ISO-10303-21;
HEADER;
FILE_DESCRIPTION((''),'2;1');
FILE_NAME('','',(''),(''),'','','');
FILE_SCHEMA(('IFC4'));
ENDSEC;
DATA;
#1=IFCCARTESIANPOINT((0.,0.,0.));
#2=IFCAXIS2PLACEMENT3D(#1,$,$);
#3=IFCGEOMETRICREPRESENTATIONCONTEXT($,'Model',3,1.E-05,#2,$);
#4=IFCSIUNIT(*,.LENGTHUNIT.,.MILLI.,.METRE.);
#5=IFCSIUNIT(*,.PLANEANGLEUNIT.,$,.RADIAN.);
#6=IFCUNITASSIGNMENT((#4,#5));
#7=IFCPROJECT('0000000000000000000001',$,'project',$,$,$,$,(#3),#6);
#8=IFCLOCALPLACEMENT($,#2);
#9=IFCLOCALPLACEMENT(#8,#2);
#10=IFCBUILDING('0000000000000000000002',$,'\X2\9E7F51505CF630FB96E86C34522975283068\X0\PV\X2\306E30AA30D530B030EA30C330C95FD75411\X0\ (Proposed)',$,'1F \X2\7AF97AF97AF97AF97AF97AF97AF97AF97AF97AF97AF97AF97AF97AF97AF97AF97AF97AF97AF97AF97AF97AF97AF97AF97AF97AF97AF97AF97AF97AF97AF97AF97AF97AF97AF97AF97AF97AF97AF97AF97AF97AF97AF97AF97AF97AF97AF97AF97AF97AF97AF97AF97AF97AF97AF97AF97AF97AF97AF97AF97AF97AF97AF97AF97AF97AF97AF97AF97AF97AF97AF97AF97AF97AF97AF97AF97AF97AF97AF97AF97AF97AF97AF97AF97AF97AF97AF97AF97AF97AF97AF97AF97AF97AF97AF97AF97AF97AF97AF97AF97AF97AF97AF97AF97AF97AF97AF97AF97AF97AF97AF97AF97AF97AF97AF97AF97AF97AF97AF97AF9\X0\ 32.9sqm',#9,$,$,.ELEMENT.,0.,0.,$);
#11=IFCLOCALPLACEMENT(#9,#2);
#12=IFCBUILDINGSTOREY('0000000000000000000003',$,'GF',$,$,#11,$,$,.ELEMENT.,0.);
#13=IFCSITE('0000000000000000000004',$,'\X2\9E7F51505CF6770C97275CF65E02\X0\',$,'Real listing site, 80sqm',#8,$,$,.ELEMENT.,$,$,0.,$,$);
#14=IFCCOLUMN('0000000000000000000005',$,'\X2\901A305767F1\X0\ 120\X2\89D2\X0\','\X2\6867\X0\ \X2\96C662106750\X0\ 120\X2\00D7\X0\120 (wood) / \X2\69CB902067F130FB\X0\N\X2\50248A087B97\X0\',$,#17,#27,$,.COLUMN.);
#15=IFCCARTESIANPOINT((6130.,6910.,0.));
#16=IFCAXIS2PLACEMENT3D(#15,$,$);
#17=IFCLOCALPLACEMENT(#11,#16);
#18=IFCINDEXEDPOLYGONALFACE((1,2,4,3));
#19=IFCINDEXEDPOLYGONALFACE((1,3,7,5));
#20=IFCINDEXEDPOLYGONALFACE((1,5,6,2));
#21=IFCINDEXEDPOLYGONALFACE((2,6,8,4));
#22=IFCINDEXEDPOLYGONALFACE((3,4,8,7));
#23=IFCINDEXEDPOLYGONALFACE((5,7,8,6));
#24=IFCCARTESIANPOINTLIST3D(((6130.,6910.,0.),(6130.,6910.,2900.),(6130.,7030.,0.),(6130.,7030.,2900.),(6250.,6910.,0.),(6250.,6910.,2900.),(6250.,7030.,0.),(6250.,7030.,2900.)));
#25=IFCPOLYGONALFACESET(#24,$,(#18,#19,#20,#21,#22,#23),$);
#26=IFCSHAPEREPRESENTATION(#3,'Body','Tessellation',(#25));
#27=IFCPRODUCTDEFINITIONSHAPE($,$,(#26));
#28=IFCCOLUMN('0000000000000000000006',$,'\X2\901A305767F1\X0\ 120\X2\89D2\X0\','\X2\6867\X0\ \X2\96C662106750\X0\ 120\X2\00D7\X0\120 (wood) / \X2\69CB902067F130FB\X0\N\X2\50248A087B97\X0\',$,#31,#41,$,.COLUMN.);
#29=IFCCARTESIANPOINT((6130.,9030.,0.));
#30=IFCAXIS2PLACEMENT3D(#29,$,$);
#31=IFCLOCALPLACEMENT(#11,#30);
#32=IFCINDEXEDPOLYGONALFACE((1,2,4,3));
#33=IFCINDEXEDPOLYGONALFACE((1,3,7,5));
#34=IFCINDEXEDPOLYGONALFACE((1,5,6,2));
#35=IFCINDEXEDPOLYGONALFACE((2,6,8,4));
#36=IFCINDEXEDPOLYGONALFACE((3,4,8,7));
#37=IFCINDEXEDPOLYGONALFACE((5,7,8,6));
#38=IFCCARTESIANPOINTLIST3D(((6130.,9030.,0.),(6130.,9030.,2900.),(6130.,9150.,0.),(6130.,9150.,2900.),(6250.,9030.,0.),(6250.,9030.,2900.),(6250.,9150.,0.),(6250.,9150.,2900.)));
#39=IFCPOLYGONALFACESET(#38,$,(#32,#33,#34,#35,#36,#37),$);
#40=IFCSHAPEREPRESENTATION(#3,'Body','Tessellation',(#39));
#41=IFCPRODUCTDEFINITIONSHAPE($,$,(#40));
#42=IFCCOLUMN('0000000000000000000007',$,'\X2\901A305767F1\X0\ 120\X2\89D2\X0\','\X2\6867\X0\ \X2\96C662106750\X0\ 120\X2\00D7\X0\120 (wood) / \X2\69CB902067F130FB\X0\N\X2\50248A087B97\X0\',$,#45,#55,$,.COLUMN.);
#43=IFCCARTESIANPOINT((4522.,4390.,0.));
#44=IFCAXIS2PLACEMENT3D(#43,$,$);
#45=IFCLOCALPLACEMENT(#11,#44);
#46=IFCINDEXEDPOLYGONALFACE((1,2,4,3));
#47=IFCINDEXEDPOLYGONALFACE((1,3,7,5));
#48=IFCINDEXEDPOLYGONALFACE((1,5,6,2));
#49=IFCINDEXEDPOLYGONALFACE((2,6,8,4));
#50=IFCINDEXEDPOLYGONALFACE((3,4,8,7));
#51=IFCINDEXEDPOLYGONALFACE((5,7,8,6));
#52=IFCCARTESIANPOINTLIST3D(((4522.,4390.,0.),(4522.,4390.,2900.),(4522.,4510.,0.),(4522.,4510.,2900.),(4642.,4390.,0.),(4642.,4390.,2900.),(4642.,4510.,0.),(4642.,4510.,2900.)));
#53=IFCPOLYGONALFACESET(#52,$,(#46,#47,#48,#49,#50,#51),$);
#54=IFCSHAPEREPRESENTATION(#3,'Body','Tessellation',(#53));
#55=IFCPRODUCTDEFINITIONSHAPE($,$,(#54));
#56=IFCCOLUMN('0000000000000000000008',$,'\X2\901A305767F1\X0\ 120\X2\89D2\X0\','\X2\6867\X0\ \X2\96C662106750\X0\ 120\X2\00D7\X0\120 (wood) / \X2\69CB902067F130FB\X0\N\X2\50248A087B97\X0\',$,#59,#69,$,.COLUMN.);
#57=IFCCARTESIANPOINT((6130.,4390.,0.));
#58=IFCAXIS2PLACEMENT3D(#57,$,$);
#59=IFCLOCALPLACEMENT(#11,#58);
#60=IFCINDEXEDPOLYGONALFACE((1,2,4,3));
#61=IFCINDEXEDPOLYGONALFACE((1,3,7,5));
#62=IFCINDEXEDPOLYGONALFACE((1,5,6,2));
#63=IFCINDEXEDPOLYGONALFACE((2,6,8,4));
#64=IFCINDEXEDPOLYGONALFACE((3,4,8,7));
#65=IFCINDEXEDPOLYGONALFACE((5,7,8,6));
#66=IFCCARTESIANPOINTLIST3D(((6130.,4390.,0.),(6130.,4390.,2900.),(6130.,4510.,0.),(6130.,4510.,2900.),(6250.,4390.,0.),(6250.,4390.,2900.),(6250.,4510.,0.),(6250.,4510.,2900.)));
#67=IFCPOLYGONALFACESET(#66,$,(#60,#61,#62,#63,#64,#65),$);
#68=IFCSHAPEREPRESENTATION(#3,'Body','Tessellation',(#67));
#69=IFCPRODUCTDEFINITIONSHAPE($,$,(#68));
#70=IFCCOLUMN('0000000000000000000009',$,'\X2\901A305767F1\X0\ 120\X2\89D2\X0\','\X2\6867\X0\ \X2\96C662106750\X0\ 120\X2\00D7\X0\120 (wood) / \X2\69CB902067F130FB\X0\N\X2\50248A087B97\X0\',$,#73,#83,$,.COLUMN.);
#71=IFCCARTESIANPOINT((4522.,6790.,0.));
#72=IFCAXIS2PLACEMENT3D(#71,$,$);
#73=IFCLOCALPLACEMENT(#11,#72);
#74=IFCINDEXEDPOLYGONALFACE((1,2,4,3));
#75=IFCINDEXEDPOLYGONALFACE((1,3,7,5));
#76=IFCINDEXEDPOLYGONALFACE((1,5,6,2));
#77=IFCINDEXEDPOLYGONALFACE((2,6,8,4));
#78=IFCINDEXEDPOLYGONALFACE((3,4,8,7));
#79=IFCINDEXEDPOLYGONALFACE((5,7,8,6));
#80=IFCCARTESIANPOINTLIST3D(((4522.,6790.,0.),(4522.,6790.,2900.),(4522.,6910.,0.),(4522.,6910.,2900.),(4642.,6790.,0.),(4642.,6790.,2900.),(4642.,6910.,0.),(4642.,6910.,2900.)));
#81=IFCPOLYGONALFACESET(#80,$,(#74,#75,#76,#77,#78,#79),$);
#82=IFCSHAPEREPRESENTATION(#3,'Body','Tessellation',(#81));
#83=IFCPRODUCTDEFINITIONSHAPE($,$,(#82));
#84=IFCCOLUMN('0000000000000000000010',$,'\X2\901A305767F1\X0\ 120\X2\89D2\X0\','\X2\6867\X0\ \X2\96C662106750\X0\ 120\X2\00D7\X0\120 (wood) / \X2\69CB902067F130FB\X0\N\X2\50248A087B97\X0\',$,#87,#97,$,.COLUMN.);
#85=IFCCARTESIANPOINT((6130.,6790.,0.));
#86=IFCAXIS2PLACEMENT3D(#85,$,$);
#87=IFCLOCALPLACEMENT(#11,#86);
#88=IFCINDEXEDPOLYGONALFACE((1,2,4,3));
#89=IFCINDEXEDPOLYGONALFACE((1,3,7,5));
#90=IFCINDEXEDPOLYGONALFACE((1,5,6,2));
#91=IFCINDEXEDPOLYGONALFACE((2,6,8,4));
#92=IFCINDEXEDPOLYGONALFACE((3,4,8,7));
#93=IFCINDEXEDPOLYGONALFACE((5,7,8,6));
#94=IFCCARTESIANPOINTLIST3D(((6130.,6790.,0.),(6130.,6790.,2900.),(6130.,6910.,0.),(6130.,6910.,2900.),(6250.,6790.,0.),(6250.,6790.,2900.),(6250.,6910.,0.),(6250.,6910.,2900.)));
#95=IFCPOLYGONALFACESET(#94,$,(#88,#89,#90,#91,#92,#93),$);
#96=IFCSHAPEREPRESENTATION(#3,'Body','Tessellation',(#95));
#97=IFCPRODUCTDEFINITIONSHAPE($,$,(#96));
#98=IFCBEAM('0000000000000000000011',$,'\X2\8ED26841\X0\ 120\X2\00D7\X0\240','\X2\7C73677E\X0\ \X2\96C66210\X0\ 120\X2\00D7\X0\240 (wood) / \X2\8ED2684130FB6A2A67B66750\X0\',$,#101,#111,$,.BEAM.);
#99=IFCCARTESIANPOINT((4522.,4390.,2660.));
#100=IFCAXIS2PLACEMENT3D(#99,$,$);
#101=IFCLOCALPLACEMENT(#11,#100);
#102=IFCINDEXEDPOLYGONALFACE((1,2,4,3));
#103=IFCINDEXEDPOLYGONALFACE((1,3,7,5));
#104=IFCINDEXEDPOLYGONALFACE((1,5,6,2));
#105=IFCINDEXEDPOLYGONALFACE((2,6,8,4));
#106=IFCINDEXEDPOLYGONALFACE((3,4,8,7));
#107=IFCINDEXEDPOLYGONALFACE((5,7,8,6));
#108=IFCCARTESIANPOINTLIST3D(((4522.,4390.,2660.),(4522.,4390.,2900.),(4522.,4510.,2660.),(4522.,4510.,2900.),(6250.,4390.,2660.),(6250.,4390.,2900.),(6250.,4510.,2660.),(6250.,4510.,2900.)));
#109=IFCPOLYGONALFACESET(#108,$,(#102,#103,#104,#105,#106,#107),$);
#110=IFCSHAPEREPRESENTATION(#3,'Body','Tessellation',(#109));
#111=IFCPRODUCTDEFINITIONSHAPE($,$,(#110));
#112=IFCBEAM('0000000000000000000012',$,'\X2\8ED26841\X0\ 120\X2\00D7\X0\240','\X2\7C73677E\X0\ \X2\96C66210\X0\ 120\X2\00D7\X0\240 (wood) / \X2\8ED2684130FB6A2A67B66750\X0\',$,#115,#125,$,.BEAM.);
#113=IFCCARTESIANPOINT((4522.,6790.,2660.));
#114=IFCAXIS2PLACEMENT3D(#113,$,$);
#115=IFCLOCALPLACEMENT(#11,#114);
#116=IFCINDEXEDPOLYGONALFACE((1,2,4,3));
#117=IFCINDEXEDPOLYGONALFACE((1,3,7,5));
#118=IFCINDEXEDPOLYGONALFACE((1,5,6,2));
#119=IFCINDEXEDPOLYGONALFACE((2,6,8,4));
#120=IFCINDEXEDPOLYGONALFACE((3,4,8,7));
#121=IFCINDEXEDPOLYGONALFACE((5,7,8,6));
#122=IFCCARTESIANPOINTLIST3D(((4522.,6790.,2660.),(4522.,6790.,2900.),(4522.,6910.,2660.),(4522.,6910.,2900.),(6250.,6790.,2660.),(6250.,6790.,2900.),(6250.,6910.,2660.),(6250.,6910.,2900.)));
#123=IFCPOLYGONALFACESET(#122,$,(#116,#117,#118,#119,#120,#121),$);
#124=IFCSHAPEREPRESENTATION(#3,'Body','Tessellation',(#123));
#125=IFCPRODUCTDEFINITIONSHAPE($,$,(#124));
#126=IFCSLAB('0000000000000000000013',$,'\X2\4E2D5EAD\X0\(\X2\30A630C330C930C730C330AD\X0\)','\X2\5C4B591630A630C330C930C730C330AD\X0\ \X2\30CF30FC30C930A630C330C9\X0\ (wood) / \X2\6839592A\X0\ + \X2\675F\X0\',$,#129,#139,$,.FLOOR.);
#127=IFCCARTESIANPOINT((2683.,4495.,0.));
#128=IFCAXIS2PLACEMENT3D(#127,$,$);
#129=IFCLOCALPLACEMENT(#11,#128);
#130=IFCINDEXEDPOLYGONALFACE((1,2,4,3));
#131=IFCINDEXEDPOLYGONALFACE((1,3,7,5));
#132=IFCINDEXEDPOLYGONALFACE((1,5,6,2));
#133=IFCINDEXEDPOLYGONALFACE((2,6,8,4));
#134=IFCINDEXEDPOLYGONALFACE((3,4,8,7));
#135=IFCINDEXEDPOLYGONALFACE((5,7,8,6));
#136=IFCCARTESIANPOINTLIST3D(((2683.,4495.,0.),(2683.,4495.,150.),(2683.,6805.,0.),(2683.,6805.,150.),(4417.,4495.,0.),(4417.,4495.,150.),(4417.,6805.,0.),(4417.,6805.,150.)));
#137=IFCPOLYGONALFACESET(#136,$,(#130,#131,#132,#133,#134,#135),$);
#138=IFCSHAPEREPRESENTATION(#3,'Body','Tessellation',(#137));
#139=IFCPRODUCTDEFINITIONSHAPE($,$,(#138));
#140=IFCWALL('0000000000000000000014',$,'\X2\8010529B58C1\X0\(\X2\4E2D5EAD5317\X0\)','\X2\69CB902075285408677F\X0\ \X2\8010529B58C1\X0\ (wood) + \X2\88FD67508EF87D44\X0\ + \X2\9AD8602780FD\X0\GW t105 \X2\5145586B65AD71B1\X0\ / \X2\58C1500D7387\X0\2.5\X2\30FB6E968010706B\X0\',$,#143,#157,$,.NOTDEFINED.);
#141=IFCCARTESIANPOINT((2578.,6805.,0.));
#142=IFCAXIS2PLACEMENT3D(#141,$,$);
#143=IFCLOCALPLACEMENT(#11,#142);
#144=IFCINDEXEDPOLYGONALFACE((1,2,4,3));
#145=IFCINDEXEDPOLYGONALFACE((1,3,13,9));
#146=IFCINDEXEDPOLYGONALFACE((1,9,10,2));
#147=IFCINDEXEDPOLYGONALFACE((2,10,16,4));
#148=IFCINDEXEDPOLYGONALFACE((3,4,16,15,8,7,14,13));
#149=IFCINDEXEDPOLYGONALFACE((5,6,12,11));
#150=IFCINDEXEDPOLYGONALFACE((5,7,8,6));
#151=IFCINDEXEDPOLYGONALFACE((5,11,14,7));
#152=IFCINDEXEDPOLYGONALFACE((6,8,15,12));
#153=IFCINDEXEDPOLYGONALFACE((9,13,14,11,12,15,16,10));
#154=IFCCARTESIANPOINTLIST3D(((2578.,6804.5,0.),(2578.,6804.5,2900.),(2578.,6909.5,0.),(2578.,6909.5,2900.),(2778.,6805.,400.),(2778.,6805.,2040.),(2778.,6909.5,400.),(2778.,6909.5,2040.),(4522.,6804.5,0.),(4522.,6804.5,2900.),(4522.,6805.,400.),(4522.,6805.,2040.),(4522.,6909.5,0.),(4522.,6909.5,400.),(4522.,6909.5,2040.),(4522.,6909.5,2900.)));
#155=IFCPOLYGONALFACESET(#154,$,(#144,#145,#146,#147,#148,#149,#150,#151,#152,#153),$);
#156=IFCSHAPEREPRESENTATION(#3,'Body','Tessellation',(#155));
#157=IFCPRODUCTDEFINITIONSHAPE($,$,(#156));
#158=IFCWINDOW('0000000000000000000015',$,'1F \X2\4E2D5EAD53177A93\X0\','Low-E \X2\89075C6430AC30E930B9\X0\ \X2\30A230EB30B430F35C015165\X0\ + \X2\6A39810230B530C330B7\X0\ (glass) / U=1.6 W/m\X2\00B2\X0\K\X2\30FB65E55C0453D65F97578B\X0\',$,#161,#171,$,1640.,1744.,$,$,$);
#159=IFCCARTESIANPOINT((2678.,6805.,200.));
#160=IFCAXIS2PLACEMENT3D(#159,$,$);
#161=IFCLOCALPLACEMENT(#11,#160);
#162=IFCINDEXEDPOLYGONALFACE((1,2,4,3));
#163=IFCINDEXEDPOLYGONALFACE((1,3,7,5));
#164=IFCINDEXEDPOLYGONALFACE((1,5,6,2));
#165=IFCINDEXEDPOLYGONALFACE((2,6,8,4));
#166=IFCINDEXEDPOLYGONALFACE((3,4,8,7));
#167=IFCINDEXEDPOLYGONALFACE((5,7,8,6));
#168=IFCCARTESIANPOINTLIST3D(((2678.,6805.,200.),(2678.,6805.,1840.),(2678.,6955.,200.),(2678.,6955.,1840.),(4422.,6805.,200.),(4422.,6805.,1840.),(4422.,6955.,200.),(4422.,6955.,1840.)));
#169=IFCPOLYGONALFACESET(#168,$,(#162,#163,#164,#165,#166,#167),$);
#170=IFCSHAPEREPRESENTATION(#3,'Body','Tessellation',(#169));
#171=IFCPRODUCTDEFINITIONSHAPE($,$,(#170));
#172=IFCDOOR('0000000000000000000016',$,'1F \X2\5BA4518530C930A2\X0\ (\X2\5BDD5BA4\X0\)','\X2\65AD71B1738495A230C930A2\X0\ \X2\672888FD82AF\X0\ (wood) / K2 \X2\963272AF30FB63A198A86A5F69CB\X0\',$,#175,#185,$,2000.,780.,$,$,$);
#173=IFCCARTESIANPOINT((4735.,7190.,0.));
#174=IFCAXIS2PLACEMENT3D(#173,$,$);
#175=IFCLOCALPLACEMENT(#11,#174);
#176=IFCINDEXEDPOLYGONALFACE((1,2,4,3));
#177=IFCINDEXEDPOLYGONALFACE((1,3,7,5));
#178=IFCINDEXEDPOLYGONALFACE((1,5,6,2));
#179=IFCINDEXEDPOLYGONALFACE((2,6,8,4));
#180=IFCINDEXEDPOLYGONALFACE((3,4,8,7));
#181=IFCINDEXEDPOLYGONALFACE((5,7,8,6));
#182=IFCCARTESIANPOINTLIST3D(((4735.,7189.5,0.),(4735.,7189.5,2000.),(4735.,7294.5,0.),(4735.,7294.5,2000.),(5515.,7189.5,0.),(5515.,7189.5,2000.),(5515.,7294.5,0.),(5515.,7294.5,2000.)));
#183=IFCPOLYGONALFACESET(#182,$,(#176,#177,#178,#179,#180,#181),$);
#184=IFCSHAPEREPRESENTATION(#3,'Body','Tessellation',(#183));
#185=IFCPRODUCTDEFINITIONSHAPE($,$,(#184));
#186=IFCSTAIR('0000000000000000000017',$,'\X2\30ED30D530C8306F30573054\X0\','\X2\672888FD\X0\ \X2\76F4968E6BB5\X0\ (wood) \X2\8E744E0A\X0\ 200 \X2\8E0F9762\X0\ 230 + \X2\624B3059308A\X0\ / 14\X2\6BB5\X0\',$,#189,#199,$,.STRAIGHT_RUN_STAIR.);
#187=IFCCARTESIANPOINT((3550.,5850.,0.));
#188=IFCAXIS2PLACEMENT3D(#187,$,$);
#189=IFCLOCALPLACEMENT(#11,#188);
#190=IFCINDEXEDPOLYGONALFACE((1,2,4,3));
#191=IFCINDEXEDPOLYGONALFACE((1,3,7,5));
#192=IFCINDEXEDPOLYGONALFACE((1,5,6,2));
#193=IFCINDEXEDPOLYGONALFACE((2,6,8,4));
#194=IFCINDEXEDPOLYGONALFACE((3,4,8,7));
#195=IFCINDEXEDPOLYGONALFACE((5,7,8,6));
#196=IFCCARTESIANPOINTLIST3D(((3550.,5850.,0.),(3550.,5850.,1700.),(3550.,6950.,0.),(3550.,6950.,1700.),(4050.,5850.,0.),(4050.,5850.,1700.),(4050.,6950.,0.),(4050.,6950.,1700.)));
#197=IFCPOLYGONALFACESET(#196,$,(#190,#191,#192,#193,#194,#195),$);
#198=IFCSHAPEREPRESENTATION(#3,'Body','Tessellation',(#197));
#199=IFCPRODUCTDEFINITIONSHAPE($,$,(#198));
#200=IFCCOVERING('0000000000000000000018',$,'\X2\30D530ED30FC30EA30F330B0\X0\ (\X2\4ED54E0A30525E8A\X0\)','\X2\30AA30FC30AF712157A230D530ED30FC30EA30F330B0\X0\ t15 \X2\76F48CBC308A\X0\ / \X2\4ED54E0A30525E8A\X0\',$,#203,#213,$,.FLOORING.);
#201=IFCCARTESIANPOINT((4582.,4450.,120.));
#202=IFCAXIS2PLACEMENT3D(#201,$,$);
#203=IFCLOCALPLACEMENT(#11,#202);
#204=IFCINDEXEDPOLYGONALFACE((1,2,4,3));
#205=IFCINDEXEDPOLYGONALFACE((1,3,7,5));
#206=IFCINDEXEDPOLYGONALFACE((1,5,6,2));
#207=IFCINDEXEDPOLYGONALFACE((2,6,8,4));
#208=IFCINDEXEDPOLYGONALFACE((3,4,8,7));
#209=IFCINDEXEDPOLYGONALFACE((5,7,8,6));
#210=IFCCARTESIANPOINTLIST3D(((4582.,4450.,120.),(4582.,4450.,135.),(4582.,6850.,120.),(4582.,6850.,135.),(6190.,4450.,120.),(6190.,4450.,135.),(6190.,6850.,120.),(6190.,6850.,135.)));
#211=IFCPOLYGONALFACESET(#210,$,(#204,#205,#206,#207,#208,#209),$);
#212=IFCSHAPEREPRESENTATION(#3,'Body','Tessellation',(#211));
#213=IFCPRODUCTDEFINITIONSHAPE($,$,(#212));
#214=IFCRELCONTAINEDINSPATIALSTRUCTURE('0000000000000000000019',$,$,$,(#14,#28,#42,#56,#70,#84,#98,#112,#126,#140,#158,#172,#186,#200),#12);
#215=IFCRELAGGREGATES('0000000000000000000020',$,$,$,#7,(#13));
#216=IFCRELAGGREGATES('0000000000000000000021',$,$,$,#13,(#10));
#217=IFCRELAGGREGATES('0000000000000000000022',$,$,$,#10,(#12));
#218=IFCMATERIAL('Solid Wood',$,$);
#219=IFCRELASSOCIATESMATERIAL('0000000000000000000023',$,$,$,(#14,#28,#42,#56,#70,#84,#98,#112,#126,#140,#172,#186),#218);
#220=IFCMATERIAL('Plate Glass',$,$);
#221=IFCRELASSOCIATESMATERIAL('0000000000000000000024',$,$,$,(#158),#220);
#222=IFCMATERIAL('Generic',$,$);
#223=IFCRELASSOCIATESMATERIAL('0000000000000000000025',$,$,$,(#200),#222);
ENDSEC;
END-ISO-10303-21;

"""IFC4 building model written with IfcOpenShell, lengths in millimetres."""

from ifc_helpers import new_model, si_unit, frame, frame_2d, origin, place, context, project, spatial, rectangle, extrude, material, element, fill, save


model = new_model("IFC4")

# Units and contexts
model_context = context("Model", 3, precision=1e-05, world=origin())
ifc_project = project(units=[si_unit("LENGTHUNIT", "METRE", prefix="MILLI"), si_unit("PLANEANGLEUNIT", "RADIAN")], contexts=[model_context])

# Site, building, storey
site_placement = place(None, origin())
site = spatial("IfcSite", under=ifc_project, at=site_placement, Name="鹿児島県霧島市", ObjectType="Real listing site, 80sqm", CompositionType="ELEMENT", RefElevation=0.0)
building_placement = place(site_placement, origin())
building = spatial("IfcBuilding", under=site, at=building_placement, Name="鹿児島・雨水利用とPVのオフグリッド志向 (Proposed)", ObjectType="1F 竹竹竹竹竹竹竹竹竹竹竹竹竹竹竹竹竹竹竹竹竹竹竹竹竹竹竹竹竹竹竹竹竹竹竹竹竹竹竹竹竹竹竹竹竹竹竹竹竹竹竹竹竹竹竹竹竹竹竹竹竹竹竹竹竹竹竹竹竹竹竹竹竹竹竹竹竹竹竹竹竹竹竹竹竹竹竹竹竹竹竹竹竹竹竹竹竹竹竹竹竹竹竹竹竹竹竹竹竹竹竹竹竹竹竹竹竹竹竹竹 32.9sqm", CompositionType="ELEMENT", ElevationOfRefHeight=0.0, ElevationOfTerrain=0.0)
storey_placement = place(building_placement, origin())
storey = spatial("IfcBuildingStorey", under=building, at=storey_placement, Name="GF", CompositionType="ELEMENT", Elevation=0.0)

# Columns
ifc_material_1 = material(Name="Solid Wood")
column_1_placement = place(storey_placement, frame((6130.0, 6910.0, 0.0)))
element("IfcColumn", 1, at=column_1_placement, inside=storey, material=ifc_material_1, Name="通し柱 120角", Description="桧 集成材 120×120 (wood) / 構造柱・N値計算", PredefinedType="COLUMN", context=model_context, shape_type="SweptSolid", body=[
    extrude(rectangle(XDim=120.0, YDim=120.0, at=frame_2d((60.0, 60.0))), frame((6130.0, 6910.0, 0.0)), (0.0, 0.0, 1.0), 2900.0),
])
column_2_placement = place(storey_placement, frame((6130.0, 9030.0, 0.0)))
element("IfcColumn", 2, at=column_2_placement, inside=storey, material=ifc_material_1, Name="通し柱 120角", Description="桧 集成材 120×120 (wood) / 構造柱・N値計算", PredefinedType="COLUMN", context=model_context, shape_type="SweptSolid", body=[
    extrude(rectangle(XDim=120.0, YDim=120.0, at=frame_2d((60.0, 60.0))), frame((6130.0, 9030.0, 0.0)), (0.0, 0.0, 1.0), 2900.0),
])
column_3_placement = place(storey_placement, frame((4522.0, 4390.0, 0.0)))
element("IfcColumn", 3, at=column_3_placement, inside=storey, material=ifc_material_1, Name="通し柱 120角", Description="桧 集成材 120×120 (wood) / 構造柱・N値計算", PredefinedType="COLUMN", context=model_context, shape_type="SweptSolid", body=[
    extrude(rectangle(XDim=120.0, YDim=120.0, at=frame_2d((60.0, 60.0))), frame((4522.0, 4390.0, 0.0)), (0.0, 0.0, 1.0), 2900.0),
])
column_4_placement = place(storey_placement, frame((6130.0, 4390.0, 0.0)))
element("IfcColumn", 4, at=column_4_placement, inside=storey, material=ifc_material_1, Name="通し柱 120角", Description="桧 集成材 120×120 (wood) / 構造柱・N値計算", PredefinedType="COLUMN", context=model_context, shape_type="SweptSolid", body=[
    extrude(rectangle(XDim=120.0, YDim=120.0, at=frame_2d((60.0, 60.0))), frame((6130.0, 4390.0, 0.0)), (0.0, 0.0, 1.0), 2900.0),
])
column_5_placement = place(storey_placement, frame((4522.0, 6790.0, 0.0)))
element("IfcColumn", 5, at=column_5_placement, inside=storey, material=ifc_material_1, Name="通し柱 120角", Description="桧 集成材 120×120 (wood) / 構造柱・N値計算", PredefinedType="COLUMN", context=model_context, shape_type="SweptSolid", body=[
    extrude(rectangle(XDim=120.0, YDim=120.0, at=frame_2d((60.0, 60.0))), frame((4522.0, 6790.0, 0.0)), (0.0, 0.0, 1.0), 2900.0),
])
column_6_placement = place(storey_placement, frame((6130.0, 6790.0, 0.0)))
element("IfcColumn", 6, at=column_6_placement, inside=storey, material=ifc_material_1, Name="通し柱 120角", Description="桧 集成材 120×120 (wood) / 構造柱・N値計算", PredefinedType="COLUMN", context=model_context, shape_type="SweptSolid", body=[
    extrude(rectangle(XDim=120.0, YDim=120.0, at=frame_2d((60.0, 60.0))), frame((6130.0, 6790.0, 0.0)), (0.0, 0.0, 1.0), 2900.0),
])

# Beams
beam_1_placement = place(storey_placement, frame((4522.0, 4390.0, 2660.0)))
element("IfcBeam", 7, at=beam_1_placement, inside=storey, material=ifc_material_1, Name="軒桁 120×240", Description="米松 集成 120×240 (wood) / 軒桁・横架材", PredefinedType="BEAM", context=model_context, shape_type="SweptSolid", body=[
    extrude(rectangle(XDim=1728.0, YDim=120.0, at=frame_2d((864.0, 60.0))), frame((4522.0, 4390.0, 2660.0)), (0.0, 0.0, 1.0), 240.0),
])
beam_2_placement = place(storey_placement, frame((4522.0, 6790.0, 2660.0)))
element("IfcBeam", 8, at=beam_2_placement, inside=storey, material=ifc_material_1, Name="軒桁 120×240", Description="米松 集成 120×240 (wood) / 軒桁・横架材", PredefinedType="BEAM", context=model_context, shape_type="SweptSolid", body=[
    extrude(rectangle(XDim=1728.0, YDim=120.0, at=frame_2d((864.0, 60.0))), frame((4522.0, 6790.0, 2660.0)), (0.0, 0.0, 1.0), 240.0),
])

# Slab
slab_placement = place(storey_placement, frame((2683.0, 4495.0, 0.0)))
element("IfcSlab", 9, at=slab_placement, inside=storey, material=ifc_material_1, Name="中庭(ウッドデッキ)", Description="屋外ウッドデッキ ハードウッド (wood) / 根太 + 束", PredefinedType="FLOOR", context=model_context, shape_type="SweptSolid", body=[
    extrude(rectangle(XDim=1734.0, YDim=2310.0, at=frame_2d((867.0, 1155.0))), frame((2683.0, 4495.0, 0.0)), (0.0, 0.0, 1.0), 150.0),
])

# Wall, opening, window
wall_1_placement = place(storey_placement, frame((2578.0, 6805.0, 0.0)))
wall_1 = element("IfcWall", 10, at=wall_1_placement, inside=storey, material=ifc_material_1, Name="耐力壁(中庭北)", Description="構造用合板 耐力壁 (wood) + 製材軸組 + 高性能GW t105 充填断熱 / 壁倍率2.5・準耐火", PredefinedType="NOTDEFINED", context=model_context, shape_type="SweptSolid", body=[
    extrude(rectangle(XDim=1944.0, YDim=105.0, at=frame_2d((972.0, 52.0))), frame((2578.0, 6805.0, 0.0)), (0.0, 0.0, 1.0), 2900.0),
])
opening_placement = place(storey_placement, frame((2678.0, 6805.0, 200.0)))
opening = element("IfcOpeningElement", 11, at=opening_placement, cuts=wall_1, PredefinedType="NOTDEFINED", context=model_context, shape_type="SweptSolid", body=[
    extrude(rectangle(XDim=1744.0, YDim=150.0, at=frame_2d((872.0, 75.0))), frame((2678.0, 6805.0, 200.0)), (0.0, 0.0, 1.0), 1640.0),
])
ifc_material_2 = material(Name="Plate Glass")
window_placement = place(storey_placement, frame((2678.0, 6805.0, 200.0)))
window = element("IfcWindow", 12, at=window_placement, inside=storey, material=ifc_material_2, Name="1F 中庭北窓", Description="Low-E 複層ガラス アルゴン封入 + 樹脂サッシ (glass) / U=1.6 W/m²K・日射取得型", OverallHeight=1640.0, OverallWidth=1744.0, context=model_context, shape_type="SweptSolid", body=[
    extrude(rectangle(XDim=1744.0, YDim=150.0, at=frame_2d((872.0, 75.0))), frame((2678.0, 6805.0, 200.0)), (0.0, 0.0, 1.0), 1640.0),
])
fill(opening, window)

# Door
door_placement = place(storey_placement, frame((4735.0, 7190.0, 0.0)))
element("IfcDoor", 13, at=door_placement, inside=storey, material=ifc_material_1, Name="1F 室内ドア (寝室)", Description="断熱玄関ドア 木製芯 (wood) / K2 防犯・採風機構", OverallHeight=2000.0, OverallWidth=780.0, context=model_context, shape_type="SweptSolid", body=[
    extrude(rectangle(XDim=780.0, YDim=105.0, at=frame_2d((390.0, 52.0))), frame((4735.0, 7190.0, 0.0)), (0.0, 0.0, 1.0), 2000.0),
])

# Stair
stair_placement = place(storey_placement, frame((3550.0, 5850.0, 0.0)))
element("IfcStair", 14, at=stair_placement, inside=storey, material=ifc_material_1, Name="ロフトはしご", Description="木製 直階段 (wood) 蹴上 200 踏面 230 + 手すり / 14段", PredefinedType="STRAIGHT_RUN_STAIR", context=model_context, shape_type="SweptSolid", body=[
    extrude(rectangle(XDim=500.0, YDim=1100.0, at=frame_2d((250.0, 550.0))), frame((3550.0, 5850.0, 0.0)), (0.0, 0.0, 1.0), 1700.0),
])

# Covering
ifc_material_3 = material(Name="Generic")
covering_placement = place(storey_placement, frame((4582.0, 4450.0, 120.0)))
element("IfcCovering", 15, at=covering_placement, inside=storey, material=ifc_material_3, Name="フローリング (仕上げ床)", Description="オーク無垢フローリング t15 直貼り / 仕上げ床", PredefinedType="FLOORING", context=model_context, shape_type="SweptSolid", body=[
    extrude(rectangle(XDim=1608.0, YDim=2400.0, at=frame_2d((804.0, 1200.0))), frame((4582.0, 4450.0, 120.0)), (0.0, 0.0, 1.0), 15.0),
])

save(model, "model.ifc")
